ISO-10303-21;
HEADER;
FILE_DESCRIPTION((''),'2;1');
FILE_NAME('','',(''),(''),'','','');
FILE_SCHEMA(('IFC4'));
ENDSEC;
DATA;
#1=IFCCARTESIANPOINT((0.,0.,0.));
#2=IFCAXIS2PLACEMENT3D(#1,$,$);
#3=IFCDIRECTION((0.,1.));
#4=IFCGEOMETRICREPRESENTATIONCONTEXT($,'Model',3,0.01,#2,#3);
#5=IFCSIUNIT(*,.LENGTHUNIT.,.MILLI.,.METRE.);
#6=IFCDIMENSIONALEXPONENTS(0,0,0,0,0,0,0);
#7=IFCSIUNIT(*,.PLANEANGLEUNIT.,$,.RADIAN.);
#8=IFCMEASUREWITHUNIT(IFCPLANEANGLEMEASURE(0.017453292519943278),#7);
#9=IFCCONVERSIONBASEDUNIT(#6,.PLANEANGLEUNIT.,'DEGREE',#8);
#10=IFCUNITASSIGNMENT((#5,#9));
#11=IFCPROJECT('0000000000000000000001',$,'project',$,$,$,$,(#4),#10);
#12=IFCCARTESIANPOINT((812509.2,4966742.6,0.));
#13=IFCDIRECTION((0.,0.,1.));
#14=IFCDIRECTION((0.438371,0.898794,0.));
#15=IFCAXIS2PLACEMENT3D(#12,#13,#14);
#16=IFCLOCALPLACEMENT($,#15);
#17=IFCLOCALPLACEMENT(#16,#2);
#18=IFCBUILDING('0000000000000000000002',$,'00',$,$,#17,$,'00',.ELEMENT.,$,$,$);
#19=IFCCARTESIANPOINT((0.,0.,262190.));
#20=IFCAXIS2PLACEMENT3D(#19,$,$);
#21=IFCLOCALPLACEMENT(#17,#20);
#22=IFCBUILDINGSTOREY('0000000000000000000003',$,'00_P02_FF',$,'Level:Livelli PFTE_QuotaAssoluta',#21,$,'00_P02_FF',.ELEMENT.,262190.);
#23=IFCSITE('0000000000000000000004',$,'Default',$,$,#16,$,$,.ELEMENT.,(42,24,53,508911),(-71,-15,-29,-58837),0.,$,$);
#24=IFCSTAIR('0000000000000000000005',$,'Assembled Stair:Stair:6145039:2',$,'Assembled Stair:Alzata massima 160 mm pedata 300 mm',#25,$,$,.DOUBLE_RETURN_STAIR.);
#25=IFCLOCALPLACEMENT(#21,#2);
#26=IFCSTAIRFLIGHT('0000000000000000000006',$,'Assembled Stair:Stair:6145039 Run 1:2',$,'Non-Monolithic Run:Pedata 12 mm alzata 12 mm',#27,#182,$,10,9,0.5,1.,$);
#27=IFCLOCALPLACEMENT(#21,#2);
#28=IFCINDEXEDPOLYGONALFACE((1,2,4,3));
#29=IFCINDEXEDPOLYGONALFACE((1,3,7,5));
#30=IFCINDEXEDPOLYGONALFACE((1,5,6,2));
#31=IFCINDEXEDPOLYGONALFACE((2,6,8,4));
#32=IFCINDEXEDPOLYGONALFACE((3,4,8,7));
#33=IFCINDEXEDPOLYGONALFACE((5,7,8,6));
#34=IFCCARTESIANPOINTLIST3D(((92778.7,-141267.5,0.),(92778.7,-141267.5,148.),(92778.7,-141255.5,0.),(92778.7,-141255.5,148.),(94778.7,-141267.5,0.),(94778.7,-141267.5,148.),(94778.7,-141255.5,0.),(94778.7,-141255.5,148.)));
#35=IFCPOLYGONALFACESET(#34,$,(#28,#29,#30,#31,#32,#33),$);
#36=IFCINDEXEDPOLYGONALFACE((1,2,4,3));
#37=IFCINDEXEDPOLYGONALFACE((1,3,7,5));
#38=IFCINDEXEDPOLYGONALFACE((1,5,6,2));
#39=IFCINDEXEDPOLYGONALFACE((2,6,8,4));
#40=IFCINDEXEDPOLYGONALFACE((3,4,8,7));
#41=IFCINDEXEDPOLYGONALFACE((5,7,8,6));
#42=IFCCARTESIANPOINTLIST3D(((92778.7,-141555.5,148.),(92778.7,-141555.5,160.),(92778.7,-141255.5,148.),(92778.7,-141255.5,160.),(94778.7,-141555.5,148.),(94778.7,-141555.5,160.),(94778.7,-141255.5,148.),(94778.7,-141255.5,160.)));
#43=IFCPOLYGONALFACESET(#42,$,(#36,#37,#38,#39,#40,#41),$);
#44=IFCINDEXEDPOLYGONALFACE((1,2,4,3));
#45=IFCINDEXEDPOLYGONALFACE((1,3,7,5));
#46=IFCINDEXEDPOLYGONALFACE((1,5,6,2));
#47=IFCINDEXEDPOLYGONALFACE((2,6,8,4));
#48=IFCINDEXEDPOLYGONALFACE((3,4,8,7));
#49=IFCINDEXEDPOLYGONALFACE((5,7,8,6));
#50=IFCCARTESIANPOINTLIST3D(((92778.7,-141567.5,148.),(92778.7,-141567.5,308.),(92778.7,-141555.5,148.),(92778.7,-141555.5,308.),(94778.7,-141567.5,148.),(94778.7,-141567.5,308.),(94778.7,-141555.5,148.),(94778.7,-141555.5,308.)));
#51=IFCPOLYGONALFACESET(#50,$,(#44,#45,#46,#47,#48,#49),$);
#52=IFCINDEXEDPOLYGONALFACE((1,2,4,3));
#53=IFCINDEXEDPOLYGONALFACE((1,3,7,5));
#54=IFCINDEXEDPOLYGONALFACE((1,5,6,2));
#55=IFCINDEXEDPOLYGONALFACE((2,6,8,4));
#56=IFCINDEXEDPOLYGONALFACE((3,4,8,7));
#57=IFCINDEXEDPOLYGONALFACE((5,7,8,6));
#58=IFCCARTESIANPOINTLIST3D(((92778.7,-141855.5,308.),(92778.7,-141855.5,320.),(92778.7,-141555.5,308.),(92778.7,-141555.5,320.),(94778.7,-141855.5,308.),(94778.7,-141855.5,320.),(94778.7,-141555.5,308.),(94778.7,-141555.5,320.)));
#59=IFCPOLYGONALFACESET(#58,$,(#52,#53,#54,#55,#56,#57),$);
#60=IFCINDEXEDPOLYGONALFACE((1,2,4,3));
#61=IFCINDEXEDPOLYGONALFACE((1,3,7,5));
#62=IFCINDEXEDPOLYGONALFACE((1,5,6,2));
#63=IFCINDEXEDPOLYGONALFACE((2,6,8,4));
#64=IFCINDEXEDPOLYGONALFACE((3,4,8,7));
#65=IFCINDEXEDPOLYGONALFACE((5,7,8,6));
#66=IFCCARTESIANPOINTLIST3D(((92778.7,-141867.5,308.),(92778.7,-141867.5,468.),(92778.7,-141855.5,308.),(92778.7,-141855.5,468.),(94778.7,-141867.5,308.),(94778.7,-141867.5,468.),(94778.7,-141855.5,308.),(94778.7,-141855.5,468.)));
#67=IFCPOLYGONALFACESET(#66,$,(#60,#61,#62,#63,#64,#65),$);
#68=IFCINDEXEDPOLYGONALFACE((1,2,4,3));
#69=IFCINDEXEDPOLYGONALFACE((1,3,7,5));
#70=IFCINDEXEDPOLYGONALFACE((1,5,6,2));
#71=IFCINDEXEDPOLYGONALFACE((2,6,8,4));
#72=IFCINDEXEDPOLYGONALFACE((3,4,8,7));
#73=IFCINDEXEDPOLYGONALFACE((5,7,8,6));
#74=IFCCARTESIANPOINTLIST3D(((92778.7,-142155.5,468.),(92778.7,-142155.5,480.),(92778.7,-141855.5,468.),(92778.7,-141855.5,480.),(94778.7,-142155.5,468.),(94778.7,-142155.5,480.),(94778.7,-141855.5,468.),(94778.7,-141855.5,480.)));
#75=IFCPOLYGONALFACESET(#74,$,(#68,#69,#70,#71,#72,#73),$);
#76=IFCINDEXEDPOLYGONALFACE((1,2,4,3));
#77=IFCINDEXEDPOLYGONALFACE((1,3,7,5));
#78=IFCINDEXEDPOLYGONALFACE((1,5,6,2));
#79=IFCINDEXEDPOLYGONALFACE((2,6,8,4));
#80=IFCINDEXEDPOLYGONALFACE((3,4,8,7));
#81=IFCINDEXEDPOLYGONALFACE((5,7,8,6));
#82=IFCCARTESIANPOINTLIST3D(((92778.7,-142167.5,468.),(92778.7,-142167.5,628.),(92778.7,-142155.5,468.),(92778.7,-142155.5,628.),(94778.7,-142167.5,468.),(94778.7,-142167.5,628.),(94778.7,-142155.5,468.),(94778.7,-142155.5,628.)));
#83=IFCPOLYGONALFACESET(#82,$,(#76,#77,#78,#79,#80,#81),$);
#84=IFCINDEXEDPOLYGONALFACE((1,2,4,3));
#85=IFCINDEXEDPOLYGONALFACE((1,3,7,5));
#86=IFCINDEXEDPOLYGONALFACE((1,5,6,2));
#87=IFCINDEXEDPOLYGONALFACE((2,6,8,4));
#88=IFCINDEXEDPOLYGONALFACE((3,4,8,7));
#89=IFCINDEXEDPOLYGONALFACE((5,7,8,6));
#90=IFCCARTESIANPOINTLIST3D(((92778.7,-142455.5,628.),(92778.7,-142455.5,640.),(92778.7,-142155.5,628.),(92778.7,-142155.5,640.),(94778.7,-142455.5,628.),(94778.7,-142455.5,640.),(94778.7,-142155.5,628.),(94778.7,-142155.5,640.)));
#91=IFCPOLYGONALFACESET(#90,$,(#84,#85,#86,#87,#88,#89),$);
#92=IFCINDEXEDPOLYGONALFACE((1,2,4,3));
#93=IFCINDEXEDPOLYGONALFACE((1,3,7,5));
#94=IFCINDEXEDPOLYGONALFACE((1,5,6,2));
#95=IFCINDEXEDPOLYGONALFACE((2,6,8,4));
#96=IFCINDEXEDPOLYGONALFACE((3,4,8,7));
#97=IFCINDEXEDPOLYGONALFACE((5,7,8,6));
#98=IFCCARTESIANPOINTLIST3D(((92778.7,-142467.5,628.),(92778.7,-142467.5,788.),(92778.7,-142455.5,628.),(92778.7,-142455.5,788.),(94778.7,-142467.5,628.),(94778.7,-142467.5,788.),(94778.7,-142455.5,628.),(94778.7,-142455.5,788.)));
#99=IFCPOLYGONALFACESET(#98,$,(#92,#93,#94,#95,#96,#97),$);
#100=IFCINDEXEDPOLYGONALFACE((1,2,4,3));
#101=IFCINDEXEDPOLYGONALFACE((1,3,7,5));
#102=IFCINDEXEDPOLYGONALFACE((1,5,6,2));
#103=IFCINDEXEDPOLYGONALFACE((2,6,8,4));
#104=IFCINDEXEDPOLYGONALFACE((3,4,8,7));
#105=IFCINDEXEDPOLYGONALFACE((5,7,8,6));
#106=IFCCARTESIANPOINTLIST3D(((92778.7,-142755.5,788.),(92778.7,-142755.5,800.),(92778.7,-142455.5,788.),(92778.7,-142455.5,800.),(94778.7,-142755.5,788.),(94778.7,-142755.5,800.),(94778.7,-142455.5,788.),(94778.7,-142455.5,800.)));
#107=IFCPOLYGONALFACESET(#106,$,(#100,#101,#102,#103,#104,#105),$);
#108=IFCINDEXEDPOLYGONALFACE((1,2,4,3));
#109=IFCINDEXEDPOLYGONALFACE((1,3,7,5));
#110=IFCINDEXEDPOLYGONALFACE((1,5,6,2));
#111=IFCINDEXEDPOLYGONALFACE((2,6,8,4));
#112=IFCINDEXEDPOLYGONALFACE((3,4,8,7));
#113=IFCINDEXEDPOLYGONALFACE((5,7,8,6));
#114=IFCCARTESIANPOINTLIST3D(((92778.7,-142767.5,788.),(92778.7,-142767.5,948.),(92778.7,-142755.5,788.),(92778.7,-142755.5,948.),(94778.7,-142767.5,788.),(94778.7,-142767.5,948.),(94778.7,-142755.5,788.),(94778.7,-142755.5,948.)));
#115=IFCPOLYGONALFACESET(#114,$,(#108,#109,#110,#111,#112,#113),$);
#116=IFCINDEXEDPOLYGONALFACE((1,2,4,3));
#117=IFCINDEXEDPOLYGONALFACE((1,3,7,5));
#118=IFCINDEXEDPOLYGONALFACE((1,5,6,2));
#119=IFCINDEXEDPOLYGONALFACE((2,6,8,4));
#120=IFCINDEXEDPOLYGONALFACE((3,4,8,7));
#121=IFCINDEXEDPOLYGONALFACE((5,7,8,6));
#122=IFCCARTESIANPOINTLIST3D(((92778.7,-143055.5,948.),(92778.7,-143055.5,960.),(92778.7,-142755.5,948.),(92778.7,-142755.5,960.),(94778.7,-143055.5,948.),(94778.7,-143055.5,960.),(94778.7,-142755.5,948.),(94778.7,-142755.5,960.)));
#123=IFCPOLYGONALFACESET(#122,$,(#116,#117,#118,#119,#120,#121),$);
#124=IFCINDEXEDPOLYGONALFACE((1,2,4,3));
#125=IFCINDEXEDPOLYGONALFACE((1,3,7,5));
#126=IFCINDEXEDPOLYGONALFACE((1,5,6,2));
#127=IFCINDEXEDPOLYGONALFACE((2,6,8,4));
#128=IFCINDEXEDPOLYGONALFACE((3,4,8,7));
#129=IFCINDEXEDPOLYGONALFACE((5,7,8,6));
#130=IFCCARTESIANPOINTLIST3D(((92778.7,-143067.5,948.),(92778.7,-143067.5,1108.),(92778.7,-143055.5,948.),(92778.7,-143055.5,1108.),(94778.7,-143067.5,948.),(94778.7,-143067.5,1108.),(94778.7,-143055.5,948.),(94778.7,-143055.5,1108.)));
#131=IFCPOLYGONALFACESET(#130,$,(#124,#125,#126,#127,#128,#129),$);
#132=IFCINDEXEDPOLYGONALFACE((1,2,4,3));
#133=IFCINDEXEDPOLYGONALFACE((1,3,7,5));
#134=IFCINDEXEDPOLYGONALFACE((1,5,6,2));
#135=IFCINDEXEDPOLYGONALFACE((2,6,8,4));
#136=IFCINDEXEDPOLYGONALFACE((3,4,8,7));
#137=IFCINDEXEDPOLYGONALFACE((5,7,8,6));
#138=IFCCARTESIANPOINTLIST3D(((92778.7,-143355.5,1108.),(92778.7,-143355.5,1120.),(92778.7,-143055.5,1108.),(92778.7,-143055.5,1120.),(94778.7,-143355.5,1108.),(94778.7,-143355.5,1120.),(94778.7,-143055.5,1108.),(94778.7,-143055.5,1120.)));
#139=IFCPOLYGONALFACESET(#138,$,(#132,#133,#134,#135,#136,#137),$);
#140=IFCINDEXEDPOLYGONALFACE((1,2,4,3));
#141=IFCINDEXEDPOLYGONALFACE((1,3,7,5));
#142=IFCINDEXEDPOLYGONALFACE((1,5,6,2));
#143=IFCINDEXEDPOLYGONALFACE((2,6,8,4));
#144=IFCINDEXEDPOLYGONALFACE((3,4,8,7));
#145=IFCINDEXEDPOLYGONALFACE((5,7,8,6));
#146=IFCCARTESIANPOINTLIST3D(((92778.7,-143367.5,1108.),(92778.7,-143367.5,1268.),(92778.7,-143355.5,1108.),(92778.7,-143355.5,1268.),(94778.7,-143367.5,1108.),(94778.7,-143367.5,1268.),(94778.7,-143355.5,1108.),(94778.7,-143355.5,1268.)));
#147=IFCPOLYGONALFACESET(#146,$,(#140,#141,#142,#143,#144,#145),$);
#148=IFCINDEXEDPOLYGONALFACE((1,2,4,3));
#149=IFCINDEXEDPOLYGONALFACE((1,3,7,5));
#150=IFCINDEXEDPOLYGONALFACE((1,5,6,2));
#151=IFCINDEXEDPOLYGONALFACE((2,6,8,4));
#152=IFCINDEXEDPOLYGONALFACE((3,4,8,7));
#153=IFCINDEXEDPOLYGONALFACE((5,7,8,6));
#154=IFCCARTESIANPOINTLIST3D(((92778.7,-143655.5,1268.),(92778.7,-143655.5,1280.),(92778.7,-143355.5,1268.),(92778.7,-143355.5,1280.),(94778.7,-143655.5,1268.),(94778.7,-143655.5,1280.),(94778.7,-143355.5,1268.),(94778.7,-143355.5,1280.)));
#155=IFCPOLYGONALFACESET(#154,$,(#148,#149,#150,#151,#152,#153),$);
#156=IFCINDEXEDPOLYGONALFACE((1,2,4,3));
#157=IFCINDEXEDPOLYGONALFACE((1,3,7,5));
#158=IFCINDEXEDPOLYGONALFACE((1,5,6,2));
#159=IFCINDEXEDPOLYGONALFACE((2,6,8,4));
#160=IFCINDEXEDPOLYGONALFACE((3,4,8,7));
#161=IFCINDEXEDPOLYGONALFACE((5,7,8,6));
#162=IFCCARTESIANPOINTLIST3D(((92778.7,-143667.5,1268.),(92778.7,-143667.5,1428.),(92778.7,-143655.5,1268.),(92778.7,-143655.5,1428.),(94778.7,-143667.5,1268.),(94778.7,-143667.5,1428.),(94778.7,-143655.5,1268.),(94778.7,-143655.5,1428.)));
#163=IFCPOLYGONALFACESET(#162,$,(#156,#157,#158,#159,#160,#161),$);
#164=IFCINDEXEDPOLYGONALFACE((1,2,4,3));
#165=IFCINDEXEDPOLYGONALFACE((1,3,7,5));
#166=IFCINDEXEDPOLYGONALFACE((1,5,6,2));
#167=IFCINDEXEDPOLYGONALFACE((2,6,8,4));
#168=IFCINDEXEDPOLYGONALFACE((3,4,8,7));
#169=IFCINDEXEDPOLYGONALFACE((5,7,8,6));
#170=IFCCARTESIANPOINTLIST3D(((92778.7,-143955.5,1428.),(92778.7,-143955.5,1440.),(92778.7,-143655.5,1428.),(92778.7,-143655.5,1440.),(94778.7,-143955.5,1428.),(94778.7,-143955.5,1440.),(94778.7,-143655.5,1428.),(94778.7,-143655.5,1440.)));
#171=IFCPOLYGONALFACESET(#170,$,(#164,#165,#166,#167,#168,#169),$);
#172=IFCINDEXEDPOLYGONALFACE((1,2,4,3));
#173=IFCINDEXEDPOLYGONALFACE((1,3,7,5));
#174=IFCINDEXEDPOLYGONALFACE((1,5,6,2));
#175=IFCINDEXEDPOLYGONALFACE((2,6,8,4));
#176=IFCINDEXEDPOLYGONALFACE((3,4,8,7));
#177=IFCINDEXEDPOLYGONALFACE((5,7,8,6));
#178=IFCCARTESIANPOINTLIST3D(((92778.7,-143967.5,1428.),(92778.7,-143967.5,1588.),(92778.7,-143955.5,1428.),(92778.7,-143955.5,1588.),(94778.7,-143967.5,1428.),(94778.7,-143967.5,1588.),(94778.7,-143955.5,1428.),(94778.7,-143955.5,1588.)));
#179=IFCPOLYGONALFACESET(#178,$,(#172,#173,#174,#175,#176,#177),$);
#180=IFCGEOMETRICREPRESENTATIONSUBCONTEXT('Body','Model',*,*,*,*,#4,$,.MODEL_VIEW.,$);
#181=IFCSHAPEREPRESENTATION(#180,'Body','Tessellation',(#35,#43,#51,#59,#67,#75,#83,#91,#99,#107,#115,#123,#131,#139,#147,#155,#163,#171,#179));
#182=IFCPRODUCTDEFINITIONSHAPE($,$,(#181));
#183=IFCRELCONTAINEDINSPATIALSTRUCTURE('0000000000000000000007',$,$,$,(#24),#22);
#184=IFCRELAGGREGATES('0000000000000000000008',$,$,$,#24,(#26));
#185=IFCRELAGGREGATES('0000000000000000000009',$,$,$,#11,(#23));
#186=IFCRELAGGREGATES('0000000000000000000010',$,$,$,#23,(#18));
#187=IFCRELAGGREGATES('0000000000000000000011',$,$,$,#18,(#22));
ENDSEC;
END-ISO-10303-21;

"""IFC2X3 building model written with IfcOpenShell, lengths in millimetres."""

from ifc_helpers import new_model, entity, si_unit, converted_unit, direction, frame, frame_2d, origin, origin_2d_with_axis, place, context, subcontext, project, spatial, rectangle, extrude, element, aggregate, save


model = new_model("IFC2X3")

# Units and contexts
model_context = context("Model", 3, precision=0.01, world=origin(), true_north=direction((0.0, 1.0)))
body_context = subcontext(model_context, "Body", "Model", "MODEL_VIEW")
ifc_project = project(units=[si_unit("LENGTHUNIT", "METRE", prefix="MILLI"), converted_unit("PLANEANGLEUNIT", "DEGREE", entity("IfcPlaneAngleMeasure", 0.017453292519943278), si_unit("PLANEANGLEUNIT", "RADIAN"), dimensions=[0, 0, 0, 0, 0, 0, 0])], contexts=[model_context])

# Site, building, storey
site_placement = place(None, frame((812509.2, 4966742.6, 0.0), z_axis=(0.0, 0.0, 1.0), x_axis=(0.438371, 0.898794, 0.0)))
site = spatial("IfcSite", under=ifc_project, at=site_placement, Name="Default", CompositionType="ELEMENT", RefLatitude=(42, 24, 53, 508911), RefLongitude=(-71, -15, -29, -58837), RefElevation=0.0)
building_placement = place(site_placement, origin())
building = spatial("IfcBuilding", under=site, at=building_placement, Name="00", LongName="00", CompositionType="ELEMENT")
storey_placement = place(building_placement, frame((0.0, 0.0, 262190.0)))
storey = spatial("IfcBuildingStorey", under=building, at=storey_placement, Name="00_P02_FF", ObjectType="Level:Livelli PFTE_QuotaAssoluta", LongName="00_P02_FF", CompositionType="ELEMENT", Elevation=262190.0)

# Stair
stair_1_placement = place(storey_placement, origin())
stair_1 = element("IfcStair", 1, at=stair_1_placement, inside=storey, Name="Assembled Stair:Stair:6145039:2", ObjectType="Assembled Stair:Alzata massima 160 mm pedata 300 mm", ShapeType="DOUBLE_RETURN_STAIR")

# Stair flight
stair_flight_1_placement = place(stair_1_placement, origin())
stair_flight_1 = element("IfcStairFlight", 2, at=stair_flight_1_placement, Name="Assembled Stair:Stair:6145039 Run 1:2", ObjectType="Non-Monolithic Run:Pedata 12 mm alzata 12 mm", NumberOfRiser=10, NumberOfTreads=9, RiserHeight=0.5, TreadLength=1.0, context=body_context, shape_type="SweptSolid", body=[
    extrude(rectangle(XDim=2000.0, YDim=12.0, at=origin_2d_with_axis()), frame((93778.7, -141261.5, 0.0)), (0.0, 0.0, 1.0), 148.0),
    extrude(rectangle(XDim=300.0, YDim=2000.0, at=frame_2d((0.0, 0.0), x_axis=(1.0, 0.0))), frame((93778.7, -141405.5, 148.0), z_axis=(0.0, 0.0, 1.0), x_axis=(0.0, 1.0, 0.0)), (0.0, 0.0, 1.0), 12.0),
    extrude(rectangle(XDim=2000.0, YDim=12.0, at=origin_2d_with_axis()), frame((93778.7, -141561.5, 148.0)), (0.0, 0.0, 1.0), 160.0),
    extrude(rectangle(XDim=300.0, YDim=2000.0, at=origin_2d_with_axis()), frame((93778.7, -141705.5, 308.0), z_axis=(0.0, 0.0, 1.0), x_axis=(0.0, 1.0, 0.0)), (0.0, 0.0, 1.0), 12.0),
    extrude(rectangle(XDim=2000.0, YDim=12.0, at=origin_2d_with_axis()), frame((93778.7, -141861.5, 308.0)), (0.0, 0.0, 1.0), 160.0),
    extrude(rectangle(XDim=300.0, YDim=2000.0, at=origin_2d_with_axis()), frame((93778.7, -142005.5, 468.0), z_axis=(0.0, 0.0, 1.0), x_axis=(0.0, 1.0, 0.0)), (0.0, 0.0, 1.0), 12.0),
    extrude(rectangle(XDim=2000.0, YDim=12.0, at=origin_2d_with_axis()), frame((93778.7, -142161.5, 468.0)), (0.0, 0.0, 1.0), 160.0),
    extrude(rectangle(XDim=300.0, YDim=2000.0, at=origin_2d_with_axis()), frame((93778.7, -142305.5, 628.0), z_axis=(0.0, 0.0, 1.0), x_axis=(0.0, 1.0, 0.0)), (0.0, 0.0, 1.0), 12.0),
    extrude(rectangle(XDim=2000.0, YDim=12.0, at=origin_2d_with_axis()), frame((93778.7, -142461.5, 628.0)), (0.0, 0.0, 1.0), 160.0),
    extrude(rectangle(XDim=300.0, YDim=2000.0, at=origin_2d_with_axis()), frame((93778.7, -142605.5, 788.0), z_axis=(0.0, 0.0, 1.0), x_axis=(0.0, 1.0, 0.0)), (0.0, 0.0, 1.0), 12.0),
    extrude(rectangle(XDim=2000.0, YDim=12.0, at=origin_2d_with_axis()), frame((93778.7, -142761.5, 788.0)), (0.0, 0.0, 1.0), 160.0),
    extrude(rectangle(XDim=300.0, YDim=2000.0, at=origin_2d_with_axis()), frame((93778.7, -142905.5, 948.0), z_axis=(0.0, 0.0, 1.0), x_axis=(0.0, 1.0, 0.0)), (0.0, 0.0, 1.0), 12.0),
    extrude(rectangle(XDim=2000.0, YDim=12.0, at=origin_2d_with_axis()), frame((93778.7, -143061.5, 948.0)), (0.0, 0.0, 1.0), 160.0),
    extrude(rectangle(XDim=300.0, YDim=2000.0, at=origin_2d_with_axis()), frame((93778.7, -143205.5, 1108.0), z_axis=(0.0, 0.0, 1.0), x_axis=(0.0, 1.0, 0.0)), (0.0, 0.0, 1.0), 12.0),
    extrude(rectangle(XDim=2000.0, YDim=12.0, at=origin_2d_with_axis()), frame((93778.7, -143361.5, 1108.0)), (0.0, 0.0, 1.0), 160.0),
    extrude(rectangle(XDim=300.0, YDim=2000.0, at=origin_2d_with_axis()), frame((93778.7, -143505.5, 1268.0), z_axis=(0.0, 0.0, 1.0), x_axis=(0.0, 1.0, 0.0)), (0.0, 0.0, 1.0), 12.0),
    extrude(rectangle(XDim=2000.0, YDim=12.0, at=origin_2d_with_axis()), frame((93778.7, -143661.5, 1268.0)), (0.0, 0.0, 1.0), 160.0),
    extrude(rectangle(XDim=300.0, YDim=2000.0, at=origin_2d_with_axis()), frame((93778.7, -143805.5, 1428.0), z_axis=(0.0, 0.0, 1.0), x_axis=(0.0, 1.0, 0.0)), (0.0, 0.0, 1.0), 12.0),
    extrude(rectangle(XDim=2000.0, YDim=12.0, at=origin_2d_with_axis()), frame((93778.7, -143961.5, 1428.0)), (0.0, 0.0, 1.0), 160.0),
])
aggregate(stair_1, [stair_flight_1])

save(model, "model.ifc")
